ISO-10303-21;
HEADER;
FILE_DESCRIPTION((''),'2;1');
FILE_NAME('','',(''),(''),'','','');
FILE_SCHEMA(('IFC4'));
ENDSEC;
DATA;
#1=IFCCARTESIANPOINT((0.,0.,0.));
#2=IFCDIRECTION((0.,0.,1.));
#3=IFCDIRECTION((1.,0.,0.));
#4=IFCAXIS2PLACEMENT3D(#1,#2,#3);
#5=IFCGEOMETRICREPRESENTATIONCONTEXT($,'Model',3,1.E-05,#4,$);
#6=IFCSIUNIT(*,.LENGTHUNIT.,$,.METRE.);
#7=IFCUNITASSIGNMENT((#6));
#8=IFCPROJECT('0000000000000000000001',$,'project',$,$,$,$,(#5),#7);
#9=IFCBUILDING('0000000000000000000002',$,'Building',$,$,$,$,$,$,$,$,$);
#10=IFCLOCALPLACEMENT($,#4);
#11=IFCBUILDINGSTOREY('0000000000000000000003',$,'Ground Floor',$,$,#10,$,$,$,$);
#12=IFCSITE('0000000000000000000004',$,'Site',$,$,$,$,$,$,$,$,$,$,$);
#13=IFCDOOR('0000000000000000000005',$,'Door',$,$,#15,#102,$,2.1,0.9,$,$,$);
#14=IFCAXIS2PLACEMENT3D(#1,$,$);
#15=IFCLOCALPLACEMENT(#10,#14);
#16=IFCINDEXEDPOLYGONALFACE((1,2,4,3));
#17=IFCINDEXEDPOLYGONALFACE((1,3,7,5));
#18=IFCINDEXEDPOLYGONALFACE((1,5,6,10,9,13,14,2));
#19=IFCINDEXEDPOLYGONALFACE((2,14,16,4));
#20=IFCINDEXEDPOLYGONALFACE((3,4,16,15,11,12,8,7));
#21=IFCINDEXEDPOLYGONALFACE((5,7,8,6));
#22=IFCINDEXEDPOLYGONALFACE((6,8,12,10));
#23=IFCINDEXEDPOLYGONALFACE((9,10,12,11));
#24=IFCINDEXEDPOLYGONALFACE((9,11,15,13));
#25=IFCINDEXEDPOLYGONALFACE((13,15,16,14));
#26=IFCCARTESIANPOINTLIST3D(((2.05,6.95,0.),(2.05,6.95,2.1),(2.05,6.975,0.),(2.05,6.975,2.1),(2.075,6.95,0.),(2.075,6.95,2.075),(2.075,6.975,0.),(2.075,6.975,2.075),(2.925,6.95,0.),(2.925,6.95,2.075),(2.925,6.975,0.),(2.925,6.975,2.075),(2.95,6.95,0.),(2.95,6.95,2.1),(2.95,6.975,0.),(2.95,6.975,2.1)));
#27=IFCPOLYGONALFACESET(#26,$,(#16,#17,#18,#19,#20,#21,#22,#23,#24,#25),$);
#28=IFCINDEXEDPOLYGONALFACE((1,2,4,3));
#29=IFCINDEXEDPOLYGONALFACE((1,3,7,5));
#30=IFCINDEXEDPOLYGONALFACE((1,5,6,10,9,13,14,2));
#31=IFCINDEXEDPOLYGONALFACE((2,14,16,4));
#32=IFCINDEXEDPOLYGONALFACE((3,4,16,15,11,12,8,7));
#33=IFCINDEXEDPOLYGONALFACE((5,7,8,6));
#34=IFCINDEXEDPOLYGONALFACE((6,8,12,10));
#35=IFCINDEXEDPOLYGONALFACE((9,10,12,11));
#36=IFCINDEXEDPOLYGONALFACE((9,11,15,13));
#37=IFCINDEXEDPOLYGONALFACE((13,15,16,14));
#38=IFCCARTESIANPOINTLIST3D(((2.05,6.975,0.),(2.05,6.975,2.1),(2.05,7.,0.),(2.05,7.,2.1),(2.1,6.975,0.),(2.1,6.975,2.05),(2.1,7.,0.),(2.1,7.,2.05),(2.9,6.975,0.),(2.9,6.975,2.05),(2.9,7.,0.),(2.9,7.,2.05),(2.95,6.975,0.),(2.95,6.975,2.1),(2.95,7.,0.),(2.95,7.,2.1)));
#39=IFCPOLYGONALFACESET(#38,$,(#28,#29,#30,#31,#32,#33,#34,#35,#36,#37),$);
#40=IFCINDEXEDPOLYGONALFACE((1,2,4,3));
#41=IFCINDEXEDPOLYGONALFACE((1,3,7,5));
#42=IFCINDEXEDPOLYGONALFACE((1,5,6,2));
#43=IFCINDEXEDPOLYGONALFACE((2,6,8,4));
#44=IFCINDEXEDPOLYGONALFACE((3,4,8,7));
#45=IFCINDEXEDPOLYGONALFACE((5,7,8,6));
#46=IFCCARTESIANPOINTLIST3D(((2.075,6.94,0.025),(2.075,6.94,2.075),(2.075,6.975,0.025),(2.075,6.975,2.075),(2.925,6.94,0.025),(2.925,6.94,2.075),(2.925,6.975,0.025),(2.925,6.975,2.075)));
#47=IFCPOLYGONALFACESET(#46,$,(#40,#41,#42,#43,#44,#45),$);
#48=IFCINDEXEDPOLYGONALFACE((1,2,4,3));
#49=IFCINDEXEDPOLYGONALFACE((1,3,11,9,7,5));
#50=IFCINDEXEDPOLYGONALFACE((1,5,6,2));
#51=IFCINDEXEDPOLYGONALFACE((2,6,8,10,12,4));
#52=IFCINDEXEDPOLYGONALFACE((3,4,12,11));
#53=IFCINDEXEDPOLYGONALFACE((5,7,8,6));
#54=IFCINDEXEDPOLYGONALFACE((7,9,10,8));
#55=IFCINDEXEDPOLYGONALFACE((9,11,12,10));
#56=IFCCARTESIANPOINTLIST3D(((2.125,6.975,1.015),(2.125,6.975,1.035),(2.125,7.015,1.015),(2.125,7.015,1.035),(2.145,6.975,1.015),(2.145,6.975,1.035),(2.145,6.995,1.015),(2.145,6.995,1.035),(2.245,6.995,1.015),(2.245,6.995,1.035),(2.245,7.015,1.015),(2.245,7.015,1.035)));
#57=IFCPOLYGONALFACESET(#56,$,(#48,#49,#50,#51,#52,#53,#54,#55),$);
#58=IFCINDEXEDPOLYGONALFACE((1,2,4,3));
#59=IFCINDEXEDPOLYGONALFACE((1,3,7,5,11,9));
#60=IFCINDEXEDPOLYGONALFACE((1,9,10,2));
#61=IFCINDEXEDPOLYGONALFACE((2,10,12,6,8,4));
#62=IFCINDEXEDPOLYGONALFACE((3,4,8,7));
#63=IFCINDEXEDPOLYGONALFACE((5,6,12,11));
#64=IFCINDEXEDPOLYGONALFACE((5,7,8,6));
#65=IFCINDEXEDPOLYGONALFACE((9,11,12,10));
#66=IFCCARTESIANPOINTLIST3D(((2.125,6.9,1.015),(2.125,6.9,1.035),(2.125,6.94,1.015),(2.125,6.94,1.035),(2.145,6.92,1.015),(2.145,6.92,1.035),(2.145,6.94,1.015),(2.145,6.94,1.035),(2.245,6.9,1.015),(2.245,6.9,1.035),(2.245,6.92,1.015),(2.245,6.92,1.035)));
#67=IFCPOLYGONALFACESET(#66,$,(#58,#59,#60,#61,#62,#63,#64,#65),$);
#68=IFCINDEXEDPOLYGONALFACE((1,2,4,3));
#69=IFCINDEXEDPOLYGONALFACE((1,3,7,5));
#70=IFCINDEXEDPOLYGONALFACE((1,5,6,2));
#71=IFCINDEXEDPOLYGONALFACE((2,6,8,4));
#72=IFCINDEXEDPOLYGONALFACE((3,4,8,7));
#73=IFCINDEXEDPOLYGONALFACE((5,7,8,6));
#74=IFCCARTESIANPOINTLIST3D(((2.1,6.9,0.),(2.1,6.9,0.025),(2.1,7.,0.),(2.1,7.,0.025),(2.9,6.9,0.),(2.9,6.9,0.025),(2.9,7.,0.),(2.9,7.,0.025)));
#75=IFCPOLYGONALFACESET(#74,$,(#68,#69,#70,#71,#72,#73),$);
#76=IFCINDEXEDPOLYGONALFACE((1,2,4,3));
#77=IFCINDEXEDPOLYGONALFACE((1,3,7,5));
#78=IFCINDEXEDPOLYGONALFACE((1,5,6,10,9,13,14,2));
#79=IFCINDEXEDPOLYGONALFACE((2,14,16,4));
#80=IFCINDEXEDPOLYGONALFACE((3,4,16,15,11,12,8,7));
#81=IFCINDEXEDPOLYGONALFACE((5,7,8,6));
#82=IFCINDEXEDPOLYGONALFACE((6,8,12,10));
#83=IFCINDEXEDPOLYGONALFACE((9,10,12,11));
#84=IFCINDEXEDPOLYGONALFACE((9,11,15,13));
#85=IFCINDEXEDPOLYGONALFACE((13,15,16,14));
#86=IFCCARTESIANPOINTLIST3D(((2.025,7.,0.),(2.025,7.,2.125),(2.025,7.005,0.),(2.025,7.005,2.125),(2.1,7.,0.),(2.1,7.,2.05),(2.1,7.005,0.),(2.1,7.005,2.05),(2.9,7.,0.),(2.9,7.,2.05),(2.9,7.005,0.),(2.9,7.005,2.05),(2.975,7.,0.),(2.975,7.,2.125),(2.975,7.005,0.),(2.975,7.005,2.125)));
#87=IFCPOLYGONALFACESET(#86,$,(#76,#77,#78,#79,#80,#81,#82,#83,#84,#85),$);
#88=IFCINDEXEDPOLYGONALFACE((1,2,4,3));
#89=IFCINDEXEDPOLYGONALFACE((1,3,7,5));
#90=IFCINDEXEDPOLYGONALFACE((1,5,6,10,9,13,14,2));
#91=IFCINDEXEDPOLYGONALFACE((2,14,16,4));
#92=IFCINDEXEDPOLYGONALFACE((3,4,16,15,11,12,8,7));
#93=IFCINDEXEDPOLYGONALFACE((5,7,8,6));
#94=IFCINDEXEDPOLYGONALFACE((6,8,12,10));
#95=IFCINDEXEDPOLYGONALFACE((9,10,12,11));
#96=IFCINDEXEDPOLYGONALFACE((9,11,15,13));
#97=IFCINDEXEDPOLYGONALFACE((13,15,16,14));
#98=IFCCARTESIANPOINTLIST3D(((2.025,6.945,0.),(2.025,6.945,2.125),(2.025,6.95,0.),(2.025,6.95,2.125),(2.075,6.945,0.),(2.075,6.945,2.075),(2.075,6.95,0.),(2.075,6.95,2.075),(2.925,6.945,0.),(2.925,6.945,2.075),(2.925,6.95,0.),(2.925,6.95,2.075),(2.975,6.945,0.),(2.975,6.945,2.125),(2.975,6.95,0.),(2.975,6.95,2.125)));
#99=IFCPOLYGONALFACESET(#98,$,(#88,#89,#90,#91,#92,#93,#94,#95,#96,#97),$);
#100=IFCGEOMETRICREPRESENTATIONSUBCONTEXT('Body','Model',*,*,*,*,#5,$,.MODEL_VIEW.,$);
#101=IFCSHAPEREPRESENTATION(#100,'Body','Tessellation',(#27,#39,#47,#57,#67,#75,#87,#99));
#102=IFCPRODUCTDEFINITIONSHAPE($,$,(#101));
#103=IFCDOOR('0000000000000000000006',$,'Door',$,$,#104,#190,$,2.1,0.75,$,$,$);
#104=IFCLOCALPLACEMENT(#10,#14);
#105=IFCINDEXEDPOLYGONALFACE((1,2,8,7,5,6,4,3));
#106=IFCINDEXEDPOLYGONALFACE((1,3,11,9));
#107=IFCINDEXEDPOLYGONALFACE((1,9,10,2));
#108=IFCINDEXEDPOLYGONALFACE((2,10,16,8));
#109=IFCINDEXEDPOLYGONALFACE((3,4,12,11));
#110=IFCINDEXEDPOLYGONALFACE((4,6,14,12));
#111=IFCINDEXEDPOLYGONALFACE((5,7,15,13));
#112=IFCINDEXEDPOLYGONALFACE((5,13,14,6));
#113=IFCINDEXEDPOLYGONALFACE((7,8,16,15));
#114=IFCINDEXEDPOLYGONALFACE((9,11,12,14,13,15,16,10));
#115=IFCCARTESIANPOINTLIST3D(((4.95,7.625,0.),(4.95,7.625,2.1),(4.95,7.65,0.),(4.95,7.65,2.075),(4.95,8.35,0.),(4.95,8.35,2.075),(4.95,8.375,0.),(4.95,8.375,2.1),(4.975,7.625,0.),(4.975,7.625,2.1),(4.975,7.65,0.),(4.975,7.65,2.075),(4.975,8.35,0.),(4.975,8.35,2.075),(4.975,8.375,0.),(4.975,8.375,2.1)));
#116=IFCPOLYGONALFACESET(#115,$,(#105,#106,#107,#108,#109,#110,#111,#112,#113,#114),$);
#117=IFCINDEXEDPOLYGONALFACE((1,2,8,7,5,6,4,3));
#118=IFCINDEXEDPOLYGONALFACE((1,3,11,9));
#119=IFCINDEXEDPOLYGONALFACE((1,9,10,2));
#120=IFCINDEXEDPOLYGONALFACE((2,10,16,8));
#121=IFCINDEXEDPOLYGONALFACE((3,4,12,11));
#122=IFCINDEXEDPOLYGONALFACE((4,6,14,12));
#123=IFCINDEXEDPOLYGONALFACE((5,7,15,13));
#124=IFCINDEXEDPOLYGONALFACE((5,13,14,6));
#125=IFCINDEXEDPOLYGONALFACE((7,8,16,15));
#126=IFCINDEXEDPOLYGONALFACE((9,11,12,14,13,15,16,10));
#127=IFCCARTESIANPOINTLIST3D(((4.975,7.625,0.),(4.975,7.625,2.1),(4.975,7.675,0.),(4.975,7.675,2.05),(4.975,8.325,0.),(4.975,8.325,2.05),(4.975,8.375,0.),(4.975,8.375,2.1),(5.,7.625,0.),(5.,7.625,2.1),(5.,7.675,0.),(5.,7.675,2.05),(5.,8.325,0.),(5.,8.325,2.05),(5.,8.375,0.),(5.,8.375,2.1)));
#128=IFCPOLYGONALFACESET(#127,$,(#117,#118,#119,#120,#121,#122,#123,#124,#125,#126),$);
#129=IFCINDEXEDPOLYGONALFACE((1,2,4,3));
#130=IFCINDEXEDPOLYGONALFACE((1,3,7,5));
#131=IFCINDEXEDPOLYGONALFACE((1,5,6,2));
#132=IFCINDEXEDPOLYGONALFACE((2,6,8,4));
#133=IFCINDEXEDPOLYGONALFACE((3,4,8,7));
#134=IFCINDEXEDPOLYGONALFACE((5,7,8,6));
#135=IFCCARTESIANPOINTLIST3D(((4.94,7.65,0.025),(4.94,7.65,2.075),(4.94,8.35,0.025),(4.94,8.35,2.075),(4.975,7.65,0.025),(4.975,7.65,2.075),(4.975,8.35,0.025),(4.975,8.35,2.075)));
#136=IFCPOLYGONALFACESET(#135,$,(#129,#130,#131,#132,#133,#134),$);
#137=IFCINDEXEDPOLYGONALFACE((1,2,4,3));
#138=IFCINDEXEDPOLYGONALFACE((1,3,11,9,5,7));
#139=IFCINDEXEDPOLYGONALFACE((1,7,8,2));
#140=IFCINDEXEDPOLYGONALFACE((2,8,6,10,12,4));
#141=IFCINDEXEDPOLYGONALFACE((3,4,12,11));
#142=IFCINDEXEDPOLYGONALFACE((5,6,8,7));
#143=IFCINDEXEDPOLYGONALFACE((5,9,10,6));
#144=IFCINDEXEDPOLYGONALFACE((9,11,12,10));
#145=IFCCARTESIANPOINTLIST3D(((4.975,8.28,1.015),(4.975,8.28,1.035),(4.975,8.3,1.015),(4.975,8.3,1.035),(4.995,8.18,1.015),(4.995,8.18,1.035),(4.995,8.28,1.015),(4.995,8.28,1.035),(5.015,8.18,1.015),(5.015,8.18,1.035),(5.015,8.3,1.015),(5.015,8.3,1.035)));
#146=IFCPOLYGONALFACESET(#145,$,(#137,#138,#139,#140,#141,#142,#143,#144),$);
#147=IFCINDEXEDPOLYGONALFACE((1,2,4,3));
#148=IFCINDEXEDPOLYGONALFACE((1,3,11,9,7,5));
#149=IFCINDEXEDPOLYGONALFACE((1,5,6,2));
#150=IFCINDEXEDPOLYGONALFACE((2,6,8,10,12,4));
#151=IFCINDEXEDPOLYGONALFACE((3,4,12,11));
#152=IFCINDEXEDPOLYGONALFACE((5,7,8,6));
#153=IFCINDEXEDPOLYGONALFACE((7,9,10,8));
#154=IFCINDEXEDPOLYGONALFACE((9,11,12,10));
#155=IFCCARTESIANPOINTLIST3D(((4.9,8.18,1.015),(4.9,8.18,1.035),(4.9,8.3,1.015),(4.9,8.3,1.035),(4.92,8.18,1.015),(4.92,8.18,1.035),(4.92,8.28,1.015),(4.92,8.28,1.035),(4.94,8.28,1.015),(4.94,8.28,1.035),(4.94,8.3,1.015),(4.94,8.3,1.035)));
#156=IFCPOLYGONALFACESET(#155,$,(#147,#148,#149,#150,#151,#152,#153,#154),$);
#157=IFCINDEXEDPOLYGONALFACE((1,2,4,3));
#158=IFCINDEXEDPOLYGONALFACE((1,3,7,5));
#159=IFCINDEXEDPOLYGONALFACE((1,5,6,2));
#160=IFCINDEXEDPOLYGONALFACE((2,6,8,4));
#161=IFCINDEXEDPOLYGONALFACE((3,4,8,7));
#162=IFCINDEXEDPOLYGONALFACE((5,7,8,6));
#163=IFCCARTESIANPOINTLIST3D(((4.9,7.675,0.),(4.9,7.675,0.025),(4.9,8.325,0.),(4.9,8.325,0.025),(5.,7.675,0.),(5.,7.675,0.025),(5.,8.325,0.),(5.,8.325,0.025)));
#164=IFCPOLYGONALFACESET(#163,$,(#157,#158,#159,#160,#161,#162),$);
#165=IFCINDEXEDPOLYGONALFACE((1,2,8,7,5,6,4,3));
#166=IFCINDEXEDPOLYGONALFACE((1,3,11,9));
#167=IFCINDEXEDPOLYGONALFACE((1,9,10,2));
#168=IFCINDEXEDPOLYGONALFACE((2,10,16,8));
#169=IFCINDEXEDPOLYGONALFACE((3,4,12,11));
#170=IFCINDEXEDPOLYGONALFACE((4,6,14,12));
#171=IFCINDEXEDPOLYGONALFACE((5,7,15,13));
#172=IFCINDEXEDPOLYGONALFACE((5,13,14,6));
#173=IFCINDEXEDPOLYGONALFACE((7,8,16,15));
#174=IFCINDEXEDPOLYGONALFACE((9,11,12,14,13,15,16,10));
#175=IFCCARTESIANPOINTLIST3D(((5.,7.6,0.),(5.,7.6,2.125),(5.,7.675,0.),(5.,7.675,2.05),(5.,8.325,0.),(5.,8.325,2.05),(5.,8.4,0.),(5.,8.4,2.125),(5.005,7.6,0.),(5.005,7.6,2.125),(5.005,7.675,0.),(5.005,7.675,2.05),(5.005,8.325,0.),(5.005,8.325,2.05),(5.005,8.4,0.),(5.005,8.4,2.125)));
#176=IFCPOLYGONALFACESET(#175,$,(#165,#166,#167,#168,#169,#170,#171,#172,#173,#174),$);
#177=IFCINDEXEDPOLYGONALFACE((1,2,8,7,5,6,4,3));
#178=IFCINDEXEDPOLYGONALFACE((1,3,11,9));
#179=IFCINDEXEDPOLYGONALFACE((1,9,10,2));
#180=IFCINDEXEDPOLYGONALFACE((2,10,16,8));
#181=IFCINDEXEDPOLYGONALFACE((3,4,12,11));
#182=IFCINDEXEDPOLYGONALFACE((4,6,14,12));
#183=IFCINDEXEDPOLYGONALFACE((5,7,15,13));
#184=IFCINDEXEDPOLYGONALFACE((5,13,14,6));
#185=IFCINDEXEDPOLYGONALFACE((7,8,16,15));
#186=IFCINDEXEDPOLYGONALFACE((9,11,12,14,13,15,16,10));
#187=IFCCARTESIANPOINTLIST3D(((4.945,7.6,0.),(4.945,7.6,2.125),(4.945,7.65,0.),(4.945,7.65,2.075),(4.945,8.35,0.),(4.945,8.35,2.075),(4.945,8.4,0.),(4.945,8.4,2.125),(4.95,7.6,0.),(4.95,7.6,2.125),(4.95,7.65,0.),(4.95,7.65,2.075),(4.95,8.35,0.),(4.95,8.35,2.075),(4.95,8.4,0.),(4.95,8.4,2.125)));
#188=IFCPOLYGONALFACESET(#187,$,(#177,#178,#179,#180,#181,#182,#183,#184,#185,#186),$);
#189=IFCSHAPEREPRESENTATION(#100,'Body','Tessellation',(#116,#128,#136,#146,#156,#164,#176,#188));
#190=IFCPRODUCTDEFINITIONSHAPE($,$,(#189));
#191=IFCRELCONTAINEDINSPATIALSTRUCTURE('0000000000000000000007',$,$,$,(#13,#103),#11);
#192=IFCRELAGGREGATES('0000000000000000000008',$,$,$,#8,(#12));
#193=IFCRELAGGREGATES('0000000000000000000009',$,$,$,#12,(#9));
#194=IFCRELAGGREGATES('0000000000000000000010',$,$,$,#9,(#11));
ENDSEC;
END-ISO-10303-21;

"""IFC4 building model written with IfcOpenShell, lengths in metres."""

from ifc_helpers import new_model, si_unit, frame, origin_with_axes, place, context, subcontext, project, spatial, line, indexed_curve, outline, extrude, element, save


model = new_model("IFC4")

# Units and contexts
model_context = context("Model", 3, precision=1e-05, world=origin_with_axes())
body_context = subcontext(model_context, "Body", "Model", "MODEL_VIEW")
ifc_project = project(units=[si_unit("LENGTHUNIT", "METRE")], contexts=[model_context])

# Site, building, storey
site = spatial("IfcSite", under=ifc_project, Name="Site")
building = spatial("IfcBuilding", under=site, Name="Building")
storey_placement = place(None, origin_with_axes())
storey = spatial("IfcBuildingStorey", under=building, at=storey_placement, Name="Ground Floor")

# Doors
door_1_placement = place(storey_placement, frame((2.95, 7.0, 0.0), z_axis=(0.0, 0.0, 1.0), x_axis=(-1.0, 0.0, 0.0)))
element("IfcDoor", 1, at=door_1_placement, inside=storey, Name="Door", OverallHeight=2.1, OverallWidth=0.9, context=body_context, shape_type="SweptSolid", body=[
    extrude(outline(indexed_curve([(0.0, 0.0), (0.0, 2.1), (0.9, 2.1), (0.9, 0.0), (0.875, 0.0), (0.875, 2.075), (0.025, 2.075), (0.025, 0.0)], segments=[line(1, 2, 3, 4, 5, 6, 7, 8, 1)])), frame((0.0, 0.025, 0.0), z_axis=(0.0, -1.0, 0.0), x_axis=(1.0, 0.0, 0.0)), (0.0, 0.0, -1.0), 0.025),
    extrude(outline(indexed_curve([(0.0, 0.0), (0.0, 2.1), (0.9, 2.1), (0.9, 0.0), (0.85, 0.0), (0.85, 2.05), (0.05, 2.05), (0.05, 0.0)], segments=[line(1, 2, 3, 4, 5, 6, 7, 8, 1)])), frame((0.0, 0.0, 0.0), z_axis=(0.0, -1.0, 0.0), x_axis=(1.0, 0.0, 0.0)), (0.0, 0.0, -1.0), 0.025),
    extrude(outline(indexed_curve([(0.0, 0.0), (0.85, 0.0), (0.85, 0.035), (0.0, 0.035)], segments=[line(1, 2, 3, 4, 1)])), frame((0.025, 0.025, 0.025), z_axis=(0.0, 0.0, 1.0), x_axis=(1.0, 0.0, 0.0)), (0.0, 0.0, 1.0), 2.05),
    extrude(outline(indexed_curve([(0.0, 0.0), (0.0, -0.04), (-0.12, -0.04), (-0.12, -0.02), (-0.02, -0.02), (-0.02, 0.0)], segments=[line(1, 2, 3, 4, 5, 6, 1)])), frame((0.825, 0.025, 1.015), z_axis=(0.0, 0.0, 1.0), x_axis=(1.0, 0.0, 0.0)), (0.0, 0.0, 1.0), 0.02),
    extrude(outline(indexed_curve([(0.0, 0.0), (0.0, 0.04), (-0.12, 0.04), (-0.12, 0.02), (-0.02, 0.02), (-0.02, 0.0)], segments=[line(1, 2, 3, 4, 5, 6, 1)])), frame((0.825, 0.06, 1.015), z_axis=(0.0, 0.0, 1.0), x_axis=(1.0, 0.0, 0.0)), (0.0, 0.0, 1.0), 0.02),
    extrude(outline(indexed_curve([(0.0, 0.0), (0.8, 0.0), (0.8, 0.1), (0.0, 0.1)], segments=[line(1, 2, 3, 4, 1)])), frame((0.05, 0.0, 0.0), z_axis=(0.0, 0.0, 1.0), x_axis=(1.0, 0.0, 0.0)), (0.0, 0.0, 1.0), 0.025),
    extrude(outline(indexed_curve([(0.0, 0.0), (0.0, 2.125), (0.95, 2.125), (0.95, 0.0), (0.875, 0.0), (0.875, 2.05), (0.075, 2.05), (0.075, 0.0)], segments=[line(1, 2, 3, 4, 5, 6, 7, 8, 1)])), frame((-0.025, -0.005, 0.0), z_axis=(0.0, -1.0, 0.0), x_axis=(1.0, 0.0, 0.0)), (0.0, 0.0, -1.0), 0.005),
    extrude(outline(indexed_curve([(0.0, 0.0), (0.0, 2.125), (0.95, 2.125), (0.95, 0.0), (0.9, 0.0), (0.9, 2.075), (0.05, 2.075), (0.05, 0.0)], segments=[line(1, 2, 3, 4, 5, 6, 7, 8, 1)])), frame((-0.025, 0.05, 0.0), z_axis=(0.0, -1.0, 0.0), x_axis=(1.0, 0.0, 0.0)), (0.0, 0.0, -1.0), 0.005),
])
door_2_placement = place(storey_placement, frame((5.0, 7.625, 0.0), z_axis=(0.0, 0.0, 1.0), x_axis=(0.0, 1.0, 0.0)))
element("IfcDoor", 2, at=door_2_placement, inside=storey, Name="Door", OverallHeight=2.1, OverallWidth=0.75, context=body_context, shape_type="SweptSolid", body=[
    extrude(outline(indexed_curve([(0.0, 0.0), (0.0, 2.1), (0.75, 2.1), (0.75, 0.0), (0.725, 0.0), (0.725, 2.075), (0.025, 2.075), (0.025, 0.0)], segments=[line(1, 2, 3, 4, 5, 6, 7, 8, 1)])), frame((0.0, 0.025, 0.0), z_axis=(0.0, -1.0, 0.0), x_axis=(1.0, 0.0, 0.0)), (0.0, 0.0, -1.0), 0.025),
    extrude(outline(indexed_curve([(0.0, 0.0), (0.0, 2.1), (0.75, 2.1), (0.75, 0.0), (0.7, 0.0), (0.7, 2.05), (0.05, 2.05), (0.05, 0.0)], segments=[line(1, 2, 3, 4, 5, 6, 7, 8, 1)])), frame((0.0, 0.0, 0.0), z_axis=(0.0, -1.0, 0.0), x_axis=(1.0, 0.0, 0.0)), (0.0, 0.0, -1.0), 0.025),
    extrude(outline(indexed_curve([(0.0, 0.0), (0.7, 0.0), (0.7, 0.035), (0.0, 0.035)], segments=[line(1, 2, 3, 4, 1)])), frame((0.025, 0.025, 0.025), z_axis=(0.0, 0.0, 1.0), x_axis=(1.0, 0.0, 0.0)), (0.0, 0.0, 1.0), 2.05),
    extrude(outline(indexed_curve([(0.0, 0.0), (0.0, -0.04), (-0.12, -0.04), (-0.12, -0.02), (-0.02, -0.02), (-0.02, 0.0)], segments=[line(1, 2, 3, 4, 5, 6, 1)])), frame((0.675, 0.025, 1.015), z_axis=(0.0, 0.0, 1.0), x_axis=(1.0, 0.0, 0.0)), (0.0, 0.0, 1.0), 0.02),
    extrude(outline(indexed_curve([(0.0, 0.0), (0.0, 0.04), (-0.12, 0.04), (-0.12, 0.02), (-0.02, 0.02), (-0.02, 0.0)], segments=[line(1, 2, 3, 4, 5, 6, 1)])), frame((0.675, 0.06, 1.015), z_axis=(0.0, 0.0, 1.0), x_axis=(1.0, 0.0, 0.0)), (0.0, 0.0, 1.0), 0.02),
    extrude(outline(indexed_curve([(0.0, 0.0), (0.65, 0.0), (0.65, 0.1), (0.0, 0.1)], segments=[line(1, 2, 3, 4, 1)])), frame((0.05, 0.0, 0.0), z_axis=(0.0, 0.0, 1.0), x_axis=(1.0, 0.0, 0.0)), (0.0, 0.0, 1.0), 0.025),
    extrude(outline(indexed_curve([(0.0, 0.0), (0.0, 2.125), (0.8, 2.125), (0.8, 0.0), (0.725, 0.0), (0.725, 2.05), (0.075, 2.05), (0.075, 0.0)], segments=[line(1, 2, 3, 4, 5, 6, 7, 8, 1)])), frame((-0.025, -0.005, 0.0), z_axis=(0.0, -1.0, 0.0), x_axis=(1.0, 0.0, 0.0)), (0.0, 0.0, -1.0), 0.005),
    extrude(outline(indexed_curve([(0.0, 0.0), (0.0, 2.125), (0.8, 2.125), (0.8, 0.0), (0.75, 0.0), (0.75, 2.075), (0.05, 2.075), (0.05, 0.0)], segments=[line(1, 2, 3, 4, 5, 6, 7, 8, 1)])), frame((-0.025, 0.05, 0.0), z_axis=(0.0, -1.0, 0.0), x_axis=(1.0, 0.0, 0.0)), (0.0, 0.0, -1.0), 0.005),
])

save(model, "model.ifc")
